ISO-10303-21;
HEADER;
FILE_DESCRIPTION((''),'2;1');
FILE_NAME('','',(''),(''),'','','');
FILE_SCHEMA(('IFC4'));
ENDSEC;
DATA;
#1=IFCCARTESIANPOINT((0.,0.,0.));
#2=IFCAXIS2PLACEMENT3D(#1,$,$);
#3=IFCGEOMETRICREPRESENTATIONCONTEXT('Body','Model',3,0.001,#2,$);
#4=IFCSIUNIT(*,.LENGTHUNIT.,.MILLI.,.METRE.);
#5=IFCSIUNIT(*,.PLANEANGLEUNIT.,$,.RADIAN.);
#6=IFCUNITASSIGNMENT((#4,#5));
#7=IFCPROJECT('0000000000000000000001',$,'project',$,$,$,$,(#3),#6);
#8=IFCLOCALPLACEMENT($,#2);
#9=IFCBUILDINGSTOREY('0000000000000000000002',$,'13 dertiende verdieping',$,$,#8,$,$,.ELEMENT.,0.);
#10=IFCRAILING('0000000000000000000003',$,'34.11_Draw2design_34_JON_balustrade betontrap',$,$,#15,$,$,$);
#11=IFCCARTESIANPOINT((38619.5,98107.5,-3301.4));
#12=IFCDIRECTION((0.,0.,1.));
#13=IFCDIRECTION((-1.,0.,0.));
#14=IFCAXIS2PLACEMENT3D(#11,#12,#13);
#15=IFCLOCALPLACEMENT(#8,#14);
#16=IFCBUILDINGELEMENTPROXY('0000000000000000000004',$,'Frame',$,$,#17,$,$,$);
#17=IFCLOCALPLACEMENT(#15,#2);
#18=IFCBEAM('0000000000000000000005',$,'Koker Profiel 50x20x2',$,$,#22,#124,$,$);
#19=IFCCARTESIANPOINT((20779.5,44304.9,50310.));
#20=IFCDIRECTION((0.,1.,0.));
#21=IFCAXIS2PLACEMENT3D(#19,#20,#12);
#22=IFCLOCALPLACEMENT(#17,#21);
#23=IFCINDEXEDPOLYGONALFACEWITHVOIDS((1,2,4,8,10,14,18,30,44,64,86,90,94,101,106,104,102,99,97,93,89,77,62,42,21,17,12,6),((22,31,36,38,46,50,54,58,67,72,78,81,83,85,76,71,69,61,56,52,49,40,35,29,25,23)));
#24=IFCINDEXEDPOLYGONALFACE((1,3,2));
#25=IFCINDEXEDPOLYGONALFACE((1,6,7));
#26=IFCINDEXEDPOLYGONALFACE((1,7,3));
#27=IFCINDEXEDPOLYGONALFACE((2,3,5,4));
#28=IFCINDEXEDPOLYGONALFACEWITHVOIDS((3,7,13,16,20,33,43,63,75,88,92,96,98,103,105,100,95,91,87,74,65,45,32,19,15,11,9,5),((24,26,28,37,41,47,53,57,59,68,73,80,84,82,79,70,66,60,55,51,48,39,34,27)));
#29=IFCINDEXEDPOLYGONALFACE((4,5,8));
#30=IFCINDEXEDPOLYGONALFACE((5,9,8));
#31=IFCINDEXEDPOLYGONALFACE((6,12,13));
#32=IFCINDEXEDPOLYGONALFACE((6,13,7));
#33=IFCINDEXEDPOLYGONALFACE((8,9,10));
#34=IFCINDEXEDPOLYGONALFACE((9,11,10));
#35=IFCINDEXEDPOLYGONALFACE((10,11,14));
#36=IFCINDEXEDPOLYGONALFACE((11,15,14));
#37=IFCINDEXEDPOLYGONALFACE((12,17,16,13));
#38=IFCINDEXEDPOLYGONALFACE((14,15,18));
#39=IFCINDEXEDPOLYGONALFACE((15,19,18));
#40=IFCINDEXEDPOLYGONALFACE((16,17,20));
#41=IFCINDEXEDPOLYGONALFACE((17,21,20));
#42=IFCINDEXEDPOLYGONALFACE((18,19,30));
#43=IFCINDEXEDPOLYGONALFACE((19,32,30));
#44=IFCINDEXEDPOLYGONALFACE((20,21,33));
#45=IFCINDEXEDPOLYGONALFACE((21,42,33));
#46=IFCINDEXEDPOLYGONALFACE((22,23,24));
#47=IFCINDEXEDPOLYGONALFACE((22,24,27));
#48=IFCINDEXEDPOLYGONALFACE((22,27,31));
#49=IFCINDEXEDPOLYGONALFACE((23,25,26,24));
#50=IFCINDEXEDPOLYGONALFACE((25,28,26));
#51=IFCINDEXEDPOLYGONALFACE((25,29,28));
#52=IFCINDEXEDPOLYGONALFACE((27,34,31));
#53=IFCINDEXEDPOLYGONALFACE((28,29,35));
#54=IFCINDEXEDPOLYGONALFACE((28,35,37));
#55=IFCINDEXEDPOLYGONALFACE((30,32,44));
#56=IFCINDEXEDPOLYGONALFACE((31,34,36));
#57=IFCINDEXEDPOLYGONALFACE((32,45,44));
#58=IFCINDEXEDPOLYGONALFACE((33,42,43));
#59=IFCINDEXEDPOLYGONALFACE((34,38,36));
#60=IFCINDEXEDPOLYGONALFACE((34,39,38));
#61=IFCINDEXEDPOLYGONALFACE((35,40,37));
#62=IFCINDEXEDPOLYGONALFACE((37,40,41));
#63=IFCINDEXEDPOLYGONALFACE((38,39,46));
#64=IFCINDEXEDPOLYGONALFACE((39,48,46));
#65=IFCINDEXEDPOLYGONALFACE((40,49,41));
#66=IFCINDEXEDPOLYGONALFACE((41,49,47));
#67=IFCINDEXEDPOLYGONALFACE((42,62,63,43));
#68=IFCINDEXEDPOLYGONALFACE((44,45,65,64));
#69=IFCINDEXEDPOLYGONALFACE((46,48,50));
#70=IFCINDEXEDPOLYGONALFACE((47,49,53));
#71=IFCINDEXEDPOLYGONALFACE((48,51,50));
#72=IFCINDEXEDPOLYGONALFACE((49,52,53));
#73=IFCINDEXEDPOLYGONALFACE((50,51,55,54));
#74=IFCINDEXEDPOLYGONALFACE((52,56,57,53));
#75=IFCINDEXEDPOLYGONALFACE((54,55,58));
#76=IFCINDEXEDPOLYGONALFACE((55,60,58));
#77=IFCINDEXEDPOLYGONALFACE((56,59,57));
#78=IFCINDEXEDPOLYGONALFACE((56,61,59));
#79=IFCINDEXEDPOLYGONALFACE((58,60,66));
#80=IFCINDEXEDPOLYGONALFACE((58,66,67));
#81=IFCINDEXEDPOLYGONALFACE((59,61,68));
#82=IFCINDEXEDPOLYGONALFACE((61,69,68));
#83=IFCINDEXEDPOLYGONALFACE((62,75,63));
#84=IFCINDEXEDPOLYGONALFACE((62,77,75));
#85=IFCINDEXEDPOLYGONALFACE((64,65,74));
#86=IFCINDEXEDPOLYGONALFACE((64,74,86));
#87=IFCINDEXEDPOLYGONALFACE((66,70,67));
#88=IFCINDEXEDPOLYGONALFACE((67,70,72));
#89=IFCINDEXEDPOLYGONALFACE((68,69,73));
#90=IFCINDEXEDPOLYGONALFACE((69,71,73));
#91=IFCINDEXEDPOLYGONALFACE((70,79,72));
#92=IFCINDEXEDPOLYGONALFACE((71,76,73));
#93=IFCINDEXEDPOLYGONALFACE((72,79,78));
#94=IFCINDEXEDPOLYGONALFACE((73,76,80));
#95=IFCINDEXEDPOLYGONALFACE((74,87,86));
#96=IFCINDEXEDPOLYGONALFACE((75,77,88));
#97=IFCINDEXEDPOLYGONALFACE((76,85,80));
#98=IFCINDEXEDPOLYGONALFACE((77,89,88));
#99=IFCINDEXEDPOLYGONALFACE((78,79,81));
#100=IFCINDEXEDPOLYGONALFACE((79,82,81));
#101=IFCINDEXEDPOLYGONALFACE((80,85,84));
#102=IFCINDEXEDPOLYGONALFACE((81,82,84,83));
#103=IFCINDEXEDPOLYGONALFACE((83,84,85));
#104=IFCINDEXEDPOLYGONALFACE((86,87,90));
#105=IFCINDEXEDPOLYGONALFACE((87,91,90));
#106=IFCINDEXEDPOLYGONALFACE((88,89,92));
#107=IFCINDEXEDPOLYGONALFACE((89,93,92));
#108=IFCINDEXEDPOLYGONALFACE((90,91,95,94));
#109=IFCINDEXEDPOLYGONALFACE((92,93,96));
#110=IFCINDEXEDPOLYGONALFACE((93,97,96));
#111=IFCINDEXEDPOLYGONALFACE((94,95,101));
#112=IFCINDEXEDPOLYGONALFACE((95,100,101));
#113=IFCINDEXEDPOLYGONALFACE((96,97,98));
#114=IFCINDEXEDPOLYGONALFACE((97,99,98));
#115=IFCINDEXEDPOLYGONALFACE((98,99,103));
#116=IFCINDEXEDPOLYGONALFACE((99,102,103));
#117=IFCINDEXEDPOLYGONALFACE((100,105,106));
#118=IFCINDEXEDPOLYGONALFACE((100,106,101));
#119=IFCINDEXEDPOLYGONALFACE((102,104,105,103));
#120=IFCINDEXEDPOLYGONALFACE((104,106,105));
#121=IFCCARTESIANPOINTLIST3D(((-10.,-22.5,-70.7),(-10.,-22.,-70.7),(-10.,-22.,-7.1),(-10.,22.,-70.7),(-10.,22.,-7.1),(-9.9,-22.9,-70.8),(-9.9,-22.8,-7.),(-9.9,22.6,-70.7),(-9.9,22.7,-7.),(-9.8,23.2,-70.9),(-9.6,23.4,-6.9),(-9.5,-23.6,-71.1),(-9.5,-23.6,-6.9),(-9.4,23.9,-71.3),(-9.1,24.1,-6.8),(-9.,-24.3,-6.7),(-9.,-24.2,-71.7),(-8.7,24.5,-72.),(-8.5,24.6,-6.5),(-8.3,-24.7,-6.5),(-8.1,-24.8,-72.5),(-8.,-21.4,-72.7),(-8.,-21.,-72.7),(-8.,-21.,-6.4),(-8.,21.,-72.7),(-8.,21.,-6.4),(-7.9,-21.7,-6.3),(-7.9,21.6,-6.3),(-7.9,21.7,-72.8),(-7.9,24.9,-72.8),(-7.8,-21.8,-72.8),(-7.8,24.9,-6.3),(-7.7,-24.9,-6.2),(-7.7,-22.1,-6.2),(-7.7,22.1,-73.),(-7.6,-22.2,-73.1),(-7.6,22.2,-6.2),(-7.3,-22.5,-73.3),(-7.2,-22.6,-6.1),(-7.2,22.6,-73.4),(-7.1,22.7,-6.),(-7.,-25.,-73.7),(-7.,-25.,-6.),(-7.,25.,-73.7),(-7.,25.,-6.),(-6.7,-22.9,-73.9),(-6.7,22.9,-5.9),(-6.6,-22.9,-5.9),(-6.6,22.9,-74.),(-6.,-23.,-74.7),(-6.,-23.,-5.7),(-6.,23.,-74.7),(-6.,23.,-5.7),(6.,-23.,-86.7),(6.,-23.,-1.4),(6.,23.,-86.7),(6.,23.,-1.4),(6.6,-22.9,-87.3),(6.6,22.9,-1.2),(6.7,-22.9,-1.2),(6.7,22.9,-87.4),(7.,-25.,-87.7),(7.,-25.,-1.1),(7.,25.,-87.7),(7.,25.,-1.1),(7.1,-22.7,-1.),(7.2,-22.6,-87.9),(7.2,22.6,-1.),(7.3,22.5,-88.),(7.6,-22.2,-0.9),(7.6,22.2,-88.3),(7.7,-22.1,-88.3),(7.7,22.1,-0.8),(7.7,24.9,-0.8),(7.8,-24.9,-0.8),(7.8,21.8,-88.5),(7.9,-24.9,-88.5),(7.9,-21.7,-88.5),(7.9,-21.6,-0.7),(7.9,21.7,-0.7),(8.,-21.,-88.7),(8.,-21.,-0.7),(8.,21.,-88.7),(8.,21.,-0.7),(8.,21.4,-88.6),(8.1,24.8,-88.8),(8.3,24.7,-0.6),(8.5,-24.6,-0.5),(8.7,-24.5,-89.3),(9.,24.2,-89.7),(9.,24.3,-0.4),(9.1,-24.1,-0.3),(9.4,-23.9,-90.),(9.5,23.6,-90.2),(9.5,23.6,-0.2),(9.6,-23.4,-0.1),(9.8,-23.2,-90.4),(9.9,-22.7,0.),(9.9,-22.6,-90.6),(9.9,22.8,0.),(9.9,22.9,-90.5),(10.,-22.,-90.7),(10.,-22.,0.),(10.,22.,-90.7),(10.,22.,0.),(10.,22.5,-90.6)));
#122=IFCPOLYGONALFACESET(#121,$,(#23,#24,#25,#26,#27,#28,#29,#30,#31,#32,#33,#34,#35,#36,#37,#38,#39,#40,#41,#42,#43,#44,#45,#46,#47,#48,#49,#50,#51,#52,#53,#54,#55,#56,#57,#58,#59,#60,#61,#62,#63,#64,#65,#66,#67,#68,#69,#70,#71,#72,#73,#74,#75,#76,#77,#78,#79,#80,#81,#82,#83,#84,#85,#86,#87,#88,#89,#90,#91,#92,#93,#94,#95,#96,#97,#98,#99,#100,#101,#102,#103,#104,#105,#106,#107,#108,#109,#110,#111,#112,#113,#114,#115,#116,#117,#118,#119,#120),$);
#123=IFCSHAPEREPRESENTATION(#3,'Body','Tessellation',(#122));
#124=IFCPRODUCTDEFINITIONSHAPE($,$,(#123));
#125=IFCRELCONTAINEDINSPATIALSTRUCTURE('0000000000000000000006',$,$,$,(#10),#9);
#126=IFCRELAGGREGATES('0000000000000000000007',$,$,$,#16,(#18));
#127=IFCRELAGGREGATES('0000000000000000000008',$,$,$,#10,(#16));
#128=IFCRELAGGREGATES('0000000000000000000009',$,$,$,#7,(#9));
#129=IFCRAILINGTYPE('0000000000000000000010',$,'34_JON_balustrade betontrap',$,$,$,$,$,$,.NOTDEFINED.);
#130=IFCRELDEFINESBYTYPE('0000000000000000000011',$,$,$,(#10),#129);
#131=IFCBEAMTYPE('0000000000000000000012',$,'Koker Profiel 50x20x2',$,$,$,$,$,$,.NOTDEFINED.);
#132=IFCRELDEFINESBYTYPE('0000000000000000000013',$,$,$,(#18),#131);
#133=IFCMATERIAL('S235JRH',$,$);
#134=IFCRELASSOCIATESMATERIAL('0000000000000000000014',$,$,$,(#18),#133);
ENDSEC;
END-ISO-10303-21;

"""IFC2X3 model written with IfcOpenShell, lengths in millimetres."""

from ifc_helpers import new_model, si_unit, frame, origin, origin_2d, place, context, project, spatial, hollow_rectangle, extrude, clip, halfspace, source, transform, mapped, material, type_object, element, aggregate, save


model = new_model("IFC2X3")

# Units and contexts
model_context = context("Model", 3, precision=0.001, world=origin(), identifier="Body")
ifc_project = project(units=[si_unit("LENGTHUNIT", "METRE", prefix="MILLI"), si_unit("PLANEANGLEUNIT", "RADIAN")], contexts=[model_context])

# Storey
storey_placement = place(None, origin())
storey = spatial("IfcBuildingStorey", under=ifc_project, at=storey_placement, Name="13 dertiende verdieping", CompositionType="ELEMENT", Elevation=0.0)

# Railing, building element proxy, beam
railing_type = type_object("IfcRailingType", Name="34_JON_balustrade betontrap")
railing_placement = place(storey_placement, frame((38619.5, 98107.5, -3301.4), z_axis=(0.0, 0.0, 1.0), x_axis=(-1.0, 0.0, 0.0)))
railing = element("IfcRailing", 1, at=railing_placement, inside=storey, type_object=railing_type, Name="34.11_Draw2design_34_JON_balustrade betontrap")
ifc_material_1 = material(Name="S235JRH")
proxy_1_placement = place(railing_placement, origin())
proxy_1 = element("IfcBuildingElementProxy", 2, at=proxy_1_placement, Name="Frame")
beam_type_1 = type_object("IfcBeamType", Name="Koker Profiel 50x20x2")
shared_shape_1 = source(origin(), model_context, "Body", "Clipping", [
    clip(clip(extrude(hollow_rectangle(XDim=20.0, YDim=50.0, WallThickness=2.0, InnerFilletRadius=2.0, OuterFilletRadius=3.0, at=origin_2d()), origin(), (0.0, 0.0, -1.0), 90.7), halfspace(frame((-10.0, 25.0, -7.1), z_axis=(-0.33335, 0.0, 0.942803), x_axis=(0.0, 1.0, 0.0)), False)), halfspace(frame((-10.0, -25.0, -70.7), z_axis=(-0.707107, 0.0, -0.707107), x_axis=(0.0, -1.0, 0.0)), False)),
])
beam_1_placement = place(proxy_1_placement, frame((20779.5, 44304.9, 50310.0), z_axis=(0.0, 1.0, 0.0), x_axis=(0.0, 0.0, 1.0)))
beam_1 = element("IfcBeam", 3, at=beam_1_placement, type_object=beam_type_1, material=ifc_material_1, Name="Koker Profiel 50x20x2", context=model_context, shape_type="MappedRepresentation", body=[
    mapped(shared_shape_1, transform((0.0, 0.0, 0.0), scale=1.0)),
])
aggregate(proxy_1, [beam_1])
aggregate(railing, [proxy_1])

save(model, "model.ifc")
